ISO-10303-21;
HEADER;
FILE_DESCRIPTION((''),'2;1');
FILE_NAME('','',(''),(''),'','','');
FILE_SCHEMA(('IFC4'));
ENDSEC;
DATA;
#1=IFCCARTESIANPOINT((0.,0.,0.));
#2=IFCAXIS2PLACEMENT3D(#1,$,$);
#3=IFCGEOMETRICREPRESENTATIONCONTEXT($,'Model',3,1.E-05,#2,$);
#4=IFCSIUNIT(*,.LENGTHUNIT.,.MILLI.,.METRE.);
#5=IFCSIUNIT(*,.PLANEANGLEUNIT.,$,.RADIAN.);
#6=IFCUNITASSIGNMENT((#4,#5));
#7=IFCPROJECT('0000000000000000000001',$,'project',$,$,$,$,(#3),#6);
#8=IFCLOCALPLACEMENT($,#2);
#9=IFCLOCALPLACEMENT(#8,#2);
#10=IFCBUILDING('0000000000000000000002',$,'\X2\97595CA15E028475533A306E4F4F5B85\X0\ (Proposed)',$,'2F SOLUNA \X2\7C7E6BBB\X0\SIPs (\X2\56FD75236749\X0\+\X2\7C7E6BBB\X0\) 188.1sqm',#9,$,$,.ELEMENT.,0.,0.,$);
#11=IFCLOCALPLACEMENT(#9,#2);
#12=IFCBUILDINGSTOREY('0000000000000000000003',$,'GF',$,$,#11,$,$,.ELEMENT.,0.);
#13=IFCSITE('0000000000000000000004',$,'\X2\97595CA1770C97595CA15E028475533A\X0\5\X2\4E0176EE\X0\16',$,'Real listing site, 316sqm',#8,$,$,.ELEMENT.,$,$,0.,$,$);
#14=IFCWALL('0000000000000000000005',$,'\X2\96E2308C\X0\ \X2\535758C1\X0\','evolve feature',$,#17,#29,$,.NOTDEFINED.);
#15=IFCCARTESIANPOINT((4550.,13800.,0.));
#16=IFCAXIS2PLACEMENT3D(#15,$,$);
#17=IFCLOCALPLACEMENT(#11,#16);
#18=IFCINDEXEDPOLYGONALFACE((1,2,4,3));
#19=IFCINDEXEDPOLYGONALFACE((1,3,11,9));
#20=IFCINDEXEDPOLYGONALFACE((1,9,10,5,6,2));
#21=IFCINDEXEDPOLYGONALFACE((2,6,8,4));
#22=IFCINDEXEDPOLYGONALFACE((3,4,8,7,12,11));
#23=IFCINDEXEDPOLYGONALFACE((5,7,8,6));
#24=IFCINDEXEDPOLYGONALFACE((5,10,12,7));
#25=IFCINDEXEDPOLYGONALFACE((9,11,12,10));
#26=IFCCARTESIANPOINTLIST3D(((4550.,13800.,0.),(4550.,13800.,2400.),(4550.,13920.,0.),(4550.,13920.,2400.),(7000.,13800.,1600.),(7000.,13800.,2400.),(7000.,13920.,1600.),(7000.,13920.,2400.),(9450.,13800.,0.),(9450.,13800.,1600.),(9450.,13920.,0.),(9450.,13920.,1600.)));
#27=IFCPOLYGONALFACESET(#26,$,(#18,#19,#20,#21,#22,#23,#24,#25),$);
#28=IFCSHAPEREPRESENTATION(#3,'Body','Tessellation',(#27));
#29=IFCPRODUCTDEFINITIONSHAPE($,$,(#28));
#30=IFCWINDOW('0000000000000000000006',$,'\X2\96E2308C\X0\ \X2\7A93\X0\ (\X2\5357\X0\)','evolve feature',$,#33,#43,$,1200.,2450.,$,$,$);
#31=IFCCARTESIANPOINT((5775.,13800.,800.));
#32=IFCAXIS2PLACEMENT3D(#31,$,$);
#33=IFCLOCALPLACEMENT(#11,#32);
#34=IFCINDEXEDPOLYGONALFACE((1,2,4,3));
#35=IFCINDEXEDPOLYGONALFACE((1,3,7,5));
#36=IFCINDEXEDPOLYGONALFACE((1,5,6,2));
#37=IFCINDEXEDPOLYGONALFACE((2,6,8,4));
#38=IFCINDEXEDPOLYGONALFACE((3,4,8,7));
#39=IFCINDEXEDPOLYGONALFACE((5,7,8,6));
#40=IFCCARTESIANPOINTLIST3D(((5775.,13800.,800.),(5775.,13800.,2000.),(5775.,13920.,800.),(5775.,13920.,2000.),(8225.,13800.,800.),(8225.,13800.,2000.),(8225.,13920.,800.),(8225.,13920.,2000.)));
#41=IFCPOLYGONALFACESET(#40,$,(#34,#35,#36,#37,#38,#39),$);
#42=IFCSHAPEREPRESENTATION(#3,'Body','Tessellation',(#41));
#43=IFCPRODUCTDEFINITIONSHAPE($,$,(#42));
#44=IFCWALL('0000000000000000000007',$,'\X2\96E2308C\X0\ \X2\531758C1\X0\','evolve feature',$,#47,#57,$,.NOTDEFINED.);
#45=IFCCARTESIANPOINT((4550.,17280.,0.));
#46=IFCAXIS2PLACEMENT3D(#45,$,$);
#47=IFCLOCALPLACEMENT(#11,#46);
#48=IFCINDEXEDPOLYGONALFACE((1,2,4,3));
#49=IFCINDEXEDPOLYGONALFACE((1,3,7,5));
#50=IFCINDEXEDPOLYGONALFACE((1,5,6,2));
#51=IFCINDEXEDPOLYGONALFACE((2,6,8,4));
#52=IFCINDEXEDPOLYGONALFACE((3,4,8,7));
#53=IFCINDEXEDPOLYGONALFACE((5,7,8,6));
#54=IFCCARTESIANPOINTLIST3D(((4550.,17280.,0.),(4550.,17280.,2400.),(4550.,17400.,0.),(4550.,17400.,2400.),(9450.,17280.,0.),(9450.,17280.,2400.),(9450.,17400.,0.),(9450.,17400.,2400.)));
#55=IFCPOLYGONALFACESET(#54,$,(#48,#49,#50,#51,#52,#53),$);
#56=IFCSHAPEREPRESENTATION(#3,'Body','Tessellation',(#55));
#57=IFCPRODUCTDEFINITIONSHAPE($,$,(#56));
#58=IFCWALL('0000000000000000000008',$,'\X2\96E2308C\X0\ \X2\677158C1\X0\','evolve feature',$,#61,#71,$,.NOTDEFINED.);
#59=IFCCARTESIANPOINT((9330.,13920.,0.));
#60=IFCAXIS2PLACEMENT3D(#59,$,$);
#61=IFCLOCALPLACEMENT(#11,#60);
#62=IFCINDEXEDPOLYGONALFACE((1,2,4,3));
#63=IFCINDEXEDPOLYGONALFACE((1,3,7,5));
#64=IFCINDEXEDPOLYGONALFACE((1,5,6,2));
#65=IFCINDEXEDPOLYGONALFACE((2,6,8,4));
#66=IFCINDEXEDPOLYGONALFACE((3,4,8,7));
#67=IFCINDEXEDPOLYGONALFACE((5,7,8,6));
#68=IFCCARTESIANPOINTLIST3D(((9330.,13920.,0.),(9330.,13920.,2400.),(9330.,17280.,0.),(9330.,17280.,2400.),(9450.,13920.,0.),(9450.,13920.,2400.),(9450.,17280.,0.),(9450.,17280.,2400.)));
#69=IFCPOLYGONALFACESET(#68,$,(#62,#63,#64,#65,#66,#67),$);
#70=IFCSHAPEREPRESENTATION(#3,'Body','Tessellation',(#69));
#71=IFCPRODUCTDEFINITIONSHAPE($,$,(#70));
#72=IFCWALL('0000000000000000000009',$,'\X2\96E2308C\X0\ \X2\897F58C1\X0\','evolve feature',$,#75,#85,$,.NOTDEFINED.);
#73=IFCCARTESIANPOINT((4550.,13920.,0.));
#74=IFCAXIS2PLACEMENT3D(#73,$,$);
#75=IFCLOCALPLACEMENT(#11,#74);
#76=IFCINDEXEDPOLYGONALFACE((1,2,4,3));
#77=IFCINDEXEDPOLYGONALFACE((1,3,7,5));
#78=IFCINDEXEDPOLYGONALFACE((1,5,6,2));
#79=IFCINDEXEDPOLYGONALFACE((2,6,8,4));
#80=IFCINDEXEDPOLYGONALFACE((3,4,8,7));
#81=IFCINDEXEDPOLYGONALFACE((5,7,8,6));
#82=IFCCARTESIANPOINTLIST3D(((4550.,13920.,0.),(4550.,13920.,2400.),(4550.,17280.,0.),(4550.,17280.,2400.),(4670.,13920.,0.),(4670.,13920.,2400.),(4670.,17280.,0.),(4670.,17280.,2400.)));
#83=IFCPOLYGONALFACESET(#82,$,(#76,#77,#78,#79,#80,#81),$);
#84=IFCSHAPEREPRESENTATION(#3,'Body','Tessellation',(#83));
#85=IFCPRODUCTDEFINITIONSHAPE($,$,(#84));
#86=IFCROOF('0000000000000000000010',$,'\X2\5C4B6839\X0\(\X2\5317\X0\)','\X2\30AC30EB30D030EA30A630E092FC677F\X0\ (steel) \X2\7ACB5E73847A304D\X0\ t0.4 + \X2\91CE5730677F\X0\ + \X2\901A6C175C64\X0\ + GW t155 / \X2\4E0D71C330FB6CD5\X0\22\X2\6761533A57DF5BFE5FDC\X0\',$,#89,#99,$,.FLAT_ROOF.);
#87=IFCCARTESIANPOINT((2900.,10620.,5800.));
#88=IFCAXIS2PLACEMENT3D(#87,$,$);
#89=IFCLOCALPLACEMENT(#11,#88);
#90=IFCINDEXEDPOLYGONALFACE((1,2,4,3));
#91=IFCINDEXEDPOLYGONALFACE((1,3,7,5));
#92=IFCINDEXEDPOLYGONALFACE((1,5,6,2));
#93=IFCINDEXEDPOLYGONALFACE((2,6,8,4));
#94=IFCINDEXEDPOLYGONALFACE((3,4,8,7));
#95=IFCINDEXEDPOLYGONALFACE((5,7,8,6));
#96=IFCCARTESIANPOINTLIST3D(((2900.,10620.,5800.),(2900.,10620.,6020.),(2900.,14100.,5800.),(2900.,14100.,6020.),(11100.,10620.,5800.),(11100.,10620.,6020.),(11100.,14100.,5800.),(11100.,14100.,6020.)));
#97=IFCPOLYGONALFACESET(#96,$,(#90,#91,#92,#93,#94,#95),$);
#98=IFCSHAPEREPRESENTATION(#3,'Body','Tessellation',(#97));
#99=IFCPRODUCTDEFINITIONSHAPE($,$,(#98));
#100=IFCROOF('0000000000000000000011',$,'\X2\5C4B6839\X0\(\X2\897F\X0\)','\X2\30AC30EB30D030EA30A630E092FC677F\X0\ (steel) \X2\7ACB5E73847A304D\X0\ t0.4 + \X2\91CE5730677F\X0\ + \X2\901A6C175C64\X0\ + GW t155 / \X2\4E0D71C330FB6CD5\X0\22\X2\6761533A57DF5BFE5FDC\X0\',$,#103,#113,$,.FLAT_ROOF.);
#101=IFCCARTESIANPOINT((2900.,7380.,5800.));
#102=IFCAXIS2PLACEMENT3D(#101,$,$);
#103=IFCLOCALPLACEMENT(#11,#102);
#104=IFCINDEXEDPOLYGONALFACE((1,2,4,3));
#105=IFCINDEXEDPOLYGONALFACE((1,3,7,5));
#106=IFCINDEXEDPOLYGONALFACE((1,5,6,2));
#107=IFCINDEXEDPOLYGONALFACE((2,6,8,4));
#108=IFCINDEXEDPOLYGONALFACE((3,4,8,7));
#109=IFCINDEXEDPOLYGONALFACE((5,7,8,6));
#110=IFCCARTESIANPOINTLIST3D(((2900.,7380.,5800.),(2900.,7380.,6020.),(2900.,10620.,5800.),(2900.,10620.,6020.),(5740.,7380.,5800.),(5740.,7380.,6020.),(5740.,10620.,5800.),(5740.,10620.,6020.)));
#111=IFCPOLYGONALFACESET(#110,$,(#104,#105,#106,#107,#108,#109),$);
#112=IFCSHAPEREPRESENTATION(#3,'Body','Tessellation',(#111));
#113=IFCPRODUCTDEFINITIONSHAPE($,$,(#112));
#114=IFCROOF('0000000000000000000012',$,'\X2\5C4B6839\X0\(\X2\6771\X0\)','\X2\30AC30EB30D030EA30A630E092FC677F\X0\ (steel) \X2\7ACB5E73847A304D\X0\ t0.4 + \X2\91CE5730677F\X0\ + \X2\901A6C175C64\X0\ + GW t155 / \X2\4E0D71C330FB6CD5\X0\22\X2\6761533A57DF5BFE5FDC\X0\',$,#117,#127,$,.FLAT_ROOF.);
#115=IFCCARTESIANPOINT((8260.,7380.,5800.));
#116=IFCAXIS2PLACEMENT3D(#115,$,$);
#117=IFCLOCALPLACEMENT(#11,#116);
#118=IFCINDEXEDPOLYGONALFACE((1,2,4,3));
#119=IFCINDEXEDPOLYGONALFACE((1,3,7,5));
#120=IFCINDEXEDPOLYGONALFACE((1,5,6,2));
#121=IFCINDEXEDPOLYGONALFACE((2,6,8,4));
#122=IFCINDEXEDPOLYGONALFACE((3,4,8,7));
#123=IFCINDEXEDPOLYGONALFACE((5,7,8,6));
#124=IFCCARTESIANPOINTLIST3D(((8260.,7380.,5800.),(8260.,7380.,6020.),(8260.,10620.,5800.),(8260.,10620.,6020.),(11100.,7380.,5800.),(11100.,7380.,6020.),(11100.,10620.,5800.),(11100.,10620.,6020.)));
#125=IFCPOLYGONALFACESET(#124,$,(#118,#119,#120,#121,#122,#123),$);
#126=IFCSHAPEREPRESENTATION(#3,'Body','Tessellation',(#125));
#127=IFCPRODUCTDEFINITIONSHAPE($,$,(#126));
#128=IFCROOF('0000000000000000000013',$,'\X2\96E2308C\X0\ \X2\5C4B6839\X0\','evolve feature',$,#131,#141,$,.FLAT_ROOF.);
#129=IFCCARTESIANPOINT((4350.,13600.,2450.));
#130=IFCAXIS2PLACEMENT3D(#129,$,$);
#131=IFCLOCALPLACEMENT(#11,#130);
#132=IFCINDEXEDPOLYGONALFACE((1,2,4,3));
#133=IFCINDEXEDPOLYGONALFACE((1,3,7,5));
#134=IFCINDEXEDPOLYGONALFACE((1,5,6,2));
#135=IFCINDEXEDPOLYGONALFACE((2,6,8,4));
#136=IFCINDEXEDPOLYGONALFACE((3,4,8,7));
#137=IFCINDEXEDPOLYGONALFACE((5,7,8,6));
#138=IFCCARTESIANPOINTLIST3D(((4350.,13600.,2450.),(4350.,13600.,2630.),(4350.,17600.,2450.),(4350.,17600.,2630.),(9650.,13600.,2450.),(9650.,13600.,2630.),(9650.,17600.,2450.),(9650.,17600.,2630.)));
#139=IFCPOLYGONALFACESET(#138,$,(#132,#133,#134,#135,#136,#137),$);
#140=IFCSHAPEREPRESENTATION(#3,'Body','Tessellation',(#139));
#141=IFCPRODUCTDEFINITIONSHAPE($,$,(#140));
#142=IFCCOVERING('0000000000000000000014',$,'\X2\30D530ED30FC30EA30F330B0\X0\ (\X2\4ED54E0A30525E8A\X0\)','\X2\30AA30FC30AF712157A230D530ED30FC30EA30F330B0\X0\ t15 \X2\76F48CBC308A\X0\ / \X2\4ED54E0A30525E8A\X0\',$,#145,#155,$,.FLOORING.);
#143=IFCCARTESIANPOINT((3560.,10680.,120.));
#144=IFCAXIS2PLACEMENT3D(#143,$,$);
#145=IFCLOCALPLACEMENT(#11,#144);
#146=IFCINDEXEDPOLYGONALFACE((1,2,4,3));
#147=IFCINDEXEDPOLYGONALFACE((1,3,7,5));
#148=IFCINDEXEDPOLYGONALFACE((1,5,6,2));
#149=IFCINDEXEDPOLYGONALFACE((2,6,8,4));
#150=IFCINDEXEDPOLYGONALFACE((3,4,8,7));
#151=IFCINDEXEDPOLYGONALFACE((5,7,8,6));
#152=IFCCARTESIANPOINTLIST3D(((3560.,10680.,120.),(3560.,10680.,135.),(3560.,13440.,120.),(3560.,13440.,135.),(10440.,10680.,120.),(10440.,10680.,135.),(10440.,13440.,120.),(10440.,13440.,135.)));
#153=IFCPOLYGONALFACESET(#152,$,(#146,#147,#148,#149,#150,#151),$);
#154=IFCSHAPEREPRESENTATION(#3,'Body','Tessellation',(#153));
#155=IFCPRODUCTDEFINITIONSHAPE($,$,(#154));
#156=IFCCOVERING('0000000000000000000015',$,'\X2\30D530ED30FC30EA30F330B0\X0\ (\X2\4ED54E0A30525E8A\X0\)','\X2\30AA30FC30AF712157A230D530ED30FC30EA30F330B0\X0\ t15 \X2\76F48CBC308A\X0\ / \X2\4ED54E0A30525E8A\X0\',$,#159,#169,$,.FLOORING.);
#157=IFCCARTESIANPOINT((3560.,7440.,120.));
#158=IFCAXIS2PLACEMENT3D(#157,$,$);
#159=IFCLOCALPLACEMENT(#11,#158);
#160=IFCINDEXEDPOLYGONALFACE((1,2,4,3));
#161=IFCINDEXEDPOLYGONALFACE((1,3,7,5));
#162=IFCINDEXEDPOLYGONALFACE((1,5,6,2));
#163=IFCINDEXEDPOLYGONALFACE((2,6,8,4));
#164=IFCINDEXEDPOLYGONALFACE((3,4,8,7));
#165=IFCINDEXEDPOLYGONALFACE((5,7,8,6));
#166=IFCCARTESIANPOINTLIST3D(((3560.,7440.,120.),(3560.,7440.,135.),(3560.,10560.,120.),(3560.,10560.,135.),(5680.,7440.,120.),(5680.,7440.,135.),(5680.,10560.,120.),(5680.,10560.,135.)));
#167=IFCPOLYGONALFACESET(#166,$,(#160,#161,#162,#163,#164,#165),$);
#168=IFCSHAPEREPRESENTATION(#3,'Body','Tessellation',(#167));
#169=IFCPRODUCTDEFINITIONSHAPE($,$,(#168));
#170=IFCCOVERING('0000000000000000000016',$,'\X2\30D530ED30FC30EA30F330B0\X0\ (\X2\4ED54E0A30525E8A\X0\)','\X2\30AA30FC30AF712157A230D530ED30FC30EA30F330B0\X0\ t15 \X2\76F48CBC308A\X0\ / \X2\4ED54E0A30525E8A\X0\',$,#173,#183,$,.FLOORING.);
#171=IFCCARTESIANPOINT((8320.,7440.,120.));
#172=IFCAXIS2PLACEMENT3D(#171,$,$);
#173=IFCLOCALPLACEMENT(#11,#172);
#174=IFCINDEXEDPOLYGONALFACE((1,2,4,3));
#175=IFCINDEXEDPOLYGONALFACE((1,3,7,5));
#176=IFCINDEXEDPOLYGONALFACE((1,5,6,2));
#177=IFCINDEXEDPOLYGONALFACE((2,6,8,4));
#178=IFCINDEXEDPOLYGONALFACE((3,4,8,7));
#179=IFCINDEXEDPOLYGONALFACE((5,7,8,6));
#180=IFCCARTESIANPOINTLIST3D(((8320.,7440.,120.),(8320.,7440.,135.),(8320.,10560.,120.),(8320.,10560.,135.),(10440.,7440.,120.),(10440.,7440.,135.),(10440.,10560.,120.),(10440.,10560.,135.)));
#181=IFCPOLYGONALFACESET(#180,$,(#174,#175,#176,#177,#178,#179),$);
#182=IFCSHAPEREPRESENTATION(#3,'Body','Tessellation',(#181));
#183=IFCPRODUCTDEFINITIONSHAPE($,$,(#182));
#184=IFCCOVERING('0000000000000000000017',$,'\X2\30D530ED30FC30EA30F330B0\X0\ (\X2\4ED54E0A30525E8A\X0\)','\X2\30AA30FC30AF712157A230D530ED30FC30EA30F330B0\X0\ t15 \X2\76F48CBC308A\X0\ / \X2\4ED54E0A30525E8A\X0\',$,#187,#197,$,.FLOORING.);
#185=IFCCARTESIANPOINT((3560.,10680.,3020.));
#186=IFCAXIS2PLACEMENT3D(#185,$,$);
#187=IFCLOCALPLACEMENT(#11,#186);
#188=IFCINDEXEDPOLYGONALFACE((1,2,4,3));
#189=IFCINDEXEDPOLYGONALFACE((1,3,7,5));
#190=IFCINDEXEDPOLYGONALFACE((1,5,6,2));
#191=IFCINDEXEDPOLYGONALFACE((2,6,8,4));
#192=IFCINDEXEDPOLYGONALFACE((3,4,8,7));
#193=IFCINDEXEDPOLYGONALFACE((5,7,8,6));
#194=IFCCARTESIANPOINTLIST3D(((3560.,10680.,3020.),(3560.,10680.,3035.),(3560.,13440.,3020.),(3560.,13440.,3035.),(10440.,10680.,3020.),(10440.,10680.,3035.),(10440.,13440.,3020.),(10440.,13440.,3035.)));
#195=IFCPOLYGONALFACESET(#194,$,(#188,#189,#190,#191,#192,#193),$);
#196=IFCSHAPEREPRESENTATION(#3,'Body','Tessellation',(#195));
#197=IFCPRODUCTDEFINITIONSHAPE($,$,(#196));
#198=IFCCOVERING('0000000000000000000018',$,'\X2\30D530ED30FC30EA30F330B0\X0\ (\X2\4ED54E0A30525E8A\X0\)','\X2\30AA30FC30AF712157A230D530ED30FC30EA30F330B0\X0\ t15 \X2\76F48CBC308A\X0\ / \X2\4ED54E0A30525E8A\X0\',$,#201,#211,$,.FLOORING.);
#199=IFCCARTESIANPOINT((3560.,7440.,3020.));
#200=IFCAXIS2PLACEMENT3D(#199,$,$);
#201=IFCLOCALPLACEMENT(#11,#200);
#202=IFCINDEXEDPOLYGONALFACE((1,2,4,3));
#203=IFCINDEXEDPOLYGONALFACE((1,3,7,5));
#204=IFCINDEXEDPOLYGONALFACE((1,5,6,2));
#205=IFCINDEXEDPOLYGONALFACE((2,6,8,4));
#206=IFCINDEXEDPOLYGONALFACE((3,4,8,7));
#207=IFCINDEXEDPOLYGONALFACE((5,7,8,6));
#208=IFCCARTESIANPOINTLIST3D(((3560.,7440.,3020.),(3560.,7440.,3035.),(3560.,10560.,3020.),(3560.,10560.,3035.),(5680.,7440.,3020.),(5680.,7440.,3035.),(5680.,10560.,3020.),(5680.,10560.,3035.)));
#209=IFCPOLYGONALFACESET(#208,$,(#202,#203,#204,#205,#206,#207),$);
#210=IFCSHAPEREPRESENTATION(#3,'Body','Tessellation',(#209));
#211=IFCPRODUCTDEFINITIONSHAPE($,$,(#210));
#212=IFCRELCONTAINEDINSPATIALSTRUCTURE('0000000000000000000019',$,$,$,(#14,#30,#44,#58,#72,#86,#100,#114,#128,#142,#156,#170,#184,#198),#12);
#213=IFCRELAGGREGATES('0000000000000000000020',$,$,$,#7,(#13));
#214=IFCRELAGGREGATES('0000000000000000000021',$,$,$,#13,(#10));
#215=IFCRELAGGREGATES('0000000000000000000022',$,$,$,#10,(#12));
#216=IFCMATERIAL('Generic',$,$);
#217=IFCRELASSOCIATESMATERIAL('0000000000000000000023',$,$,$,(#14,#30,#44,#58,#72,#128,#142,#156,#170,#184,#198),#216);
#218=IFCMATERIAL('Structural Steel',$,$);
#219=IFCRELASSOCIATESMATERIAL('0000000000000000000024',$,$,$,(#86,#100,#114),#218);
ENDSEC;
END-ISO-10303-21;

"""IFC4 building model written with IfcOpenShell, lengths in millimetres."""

from ifc_helpers import new_model, si_unit, frame, frame_2d, origin, place, context, project, spatial, rectangle, extrude, material, element, fill, save


model = new_model("IFC4")

# Units and contexts
model_context = context("Model", 3, precision=1e-05, world=origin())
ifc_project = project(units=[si_unit("LENGTHUNIT", "METRE", prefix="MILLI"), si_unit("PLANEANGLEUNIT", "RADIAN")], contexts=[model_context])

# Site, building, storey
site_placement = place(None, origin())
site = spatial("IfcSite", under=ifc_project, at=site_placement, Name="静岡県静岡市葵区5丁目16", ObjectType="Real listing site, 316sqm", CompositionType="ELEMENT", RefElevation=0.0)
building_placement = place(site_placement, origin())
building = spatial("IfcBuilding", under=site, at=building_placement, Name="静岡市葵区の住宅 (Proposed)", ObjectType="2F SOLUNA 籾殻SIPs (国産杉+籾殻) 188.1sqm", CompositionType="ELEMENT", ElevationOfRefHeight=0.0, ElevationOfTerrain=0.0)
storey_placement = place(building_placement, origin())
storey = spatial("IfcBuildingStorey", under=building, at=storey_placement, Name="GF", CompositionType="ELEMENT", Elevation=0.0)

# Shared definitions
ifc_material_1 = material(Name="Generic")

# Wall, opening, window
wall_1_placement = place(storey_placement, frame((4550.0, 13800.0, 0.0)))
wall_1 = element("IfcWall", 1, at=wall_1_placement, inside=storey, material=ifc_material_1, Name="離れ 南壁", Description="evolve feature", PredefinedType="NOTDEFINED", context=model_context, shape_type="SweptSolid", body=[
    extrude(rectangle(XDim=4900.0, YDim=120.0, at=frame_2d((2450.0, 60.0))), frame((4550.0, 13800.0, 0.0)), (0.0, 0.0, 1.0), 2400.0),
])
opening_1_placement = place(storey_placement, frame((5775.0, 13800.0, 800.0)))
opening_1 = element("IfcOpeningElement", 2, at=opening_1_placement, cuts=wall_1, PredefinedType="NOTDEFINED", context=model_context, shape_type="SweptSolid", body=[
    extrude(rectangle(XDim=2450.0, YDim=120.0, at=frame_2d((1225.0, 60.0))), frame((5775.0, 13800.0, 800.0)), (0.0, 0.0, 1.0), 1200.0),
])
window_1_placement = place(storey_placement, frame((5775.0, 13800.0, 800.0)))
window_1 = element("IfcWindow", 3, at=window_1_placement, inside=storey, material=ifc_material_1, Name="離れ 窓 (南)", Description="evolve feature", OverallHeight=1200.0, OverallWidth=2450.0, context=model_context, shape_type="SweptSolid", body=[
    extrude(rectangle(XDim=2450.0, YDim=120.0, at=frame_2d((1225.0, 60.0))), frame((5775.0, 13800.0, 800.0)), (0.0, 0.0, 1.0), 1200.0),
])
fill(opening_1, window_1)

# Walls
wall_2_placement = place(storey_placement, frame((4550.0, 17280.0, 0.0)))
element("IfcWall", 4, at=wall_2_placement, inside=storey, material=ifc_material_1, Name="離れ 北壁", Description="evolve feature", PredefinedType="NOTDEFINED", context=model_context, shape_type="SweptSolid", body=[
    extrude(rectangle(XDim=4900.0, YDim=120.0, at=frame_2d((2450.0, 60.0))), frame((4550.0, 17280.0, 0.0)), (0.0, 0.0, 1.0), 2400.0),
])
wall_3_placement = place(storey_placement, frame((9330.0, 13920.0, 0.0)))
element("IfcWall", 5, at=wall_3_placement, inside=storey, material=ifc_material_1, Name="離れ 東壁", Description="evolve feature", PredefinedType="NOTDEFINED", context=model_context, shape_type="SweptSolid", body=[
    extrude(rectangle(XDim=120.0, YDim=3360.0, at=frame_2d((60.0, 1680.0))), frame((9330.0, 13920.0, 0.0)), (0.0, 0.0, 1.0), 2400.0),
])
wall_4_placement = place(storey_placement, frame((4550.0, 13920.0, 0.0)))
element("IfcWall", 6, at=wall_4_placement, inside=storey, material=ifc_material_1, Name="離れ 西壁", Description="evolve feature", PredefinedType="NOTDEFINED", context=model_context, shape_type="SweptSolid", body=[
    extrude(rectangle(XDim=120.0, YDim=3360.0, at=frame_2d((60.0, 1680.0))), frame((4550.0, 13920.0, 0.0)), (0.0, 0.0, 1.0), 2400.0),
])

# Roofs
ifc_material_2 = material(Name="Structural Steel")
for number, where, name in (
    (7, (2900.0, 10620.0, 5800.0), "屋根(北)"),
):
    element("IfcRoof", number, at=place(storey_placement, frame(where)), inside=storey, material=ifc_material_2, Name=name, Description="ガルバリウム鋼板 (steel) 立平葺き t0.4 + 野地板 + 通気層 + GW t155 / 不燃・法22条区域対応", PredefinedType="FLAT_ROOF", context=model_context, shape_type="SweptSolid", body=[
        extrude(rectangle(XDim=8200.0, YDim=3480.0, at=frame_2d((4100.0, 1740.0))), frame((2900.0, 10620.0, 5800.0)), (0.0, 0.0, 1.0), 220.0),
    ])
roof_1_placement = place(storey_placement, frame((2900.0, 7380.0, 5800.0)))
element("IfcRoof", 8, at=roof_1_placement, inside=storey, material=ifc_material_2, Name="屋根(西)", Description="ガルバリウム鋼板 (steel) 立平葺き t0.4 + 野地板 + 通気層 + GW t155 / 不燃・法22条区域対応", PredefinedType="FLAT_ROOF", context=model_context, shape_type="SweptSolid", body=[
    extrude(rectangle(XDim=2840.0, YDim=3240.0, at=frame_2d((1420.0, 1620.0))), frame((2900.0, 7380.0, 5800.0)), (0.0, 0.0, 1.0), 220.0),
])
roof_2_placement = place(storey_placement, frame((8260.0, 7380.0, 5800.0)))
element("IfcRoof", 9, at=roof_2_placement, inside=storey, material=ifc_material_2, Name="屋根(東)", Description="ガルバリウム鋼板 (steel) 立平葺き t0.4 + 野地板 + 通気層 + GW t155 / 不燃・法22条区域対応", PredefinedType="FLAT_ROOF", context=model_context, shape_type="SweptSolid", body=[
    extrude(rectangle(XDim=2840.0, YDim=3240.0, at=frame_2d((1420.0, 1620.0))), frame((8260.0, 7380.0, 5800.0)), (0.0, 0.0, 1.0), 220.0),
])
roof_3_placement = place(storey_placement, frame((4350.0, 13600.0, 2450.0)))
element("IfcRoof", 10, at=roof_3_placement, inside=storey, material=ifc_material_1, Name="離れ 屋根", Description="evolve feature", PredefinedType="FLAT_ROOF", context=model_context, shape_type="SweptSolid", body=[
    extrude(rectangle(XDim=5300.0, YDim=4000.0, at=frame_2d((2650.0, 2000.0))), frame((4350.0, 13600.0, 2450.0)), (0.0, 0.0, 1.0), 180.0),
])

# Coverings
covering_1_placement = place(storey_placement, frame((3560.0, 10680.0, 120.0)))
element("IfcCovering", 11, at=covering_1_placement, inside=storey, material=ifc_material_1, Name="フローリング (仕上げ床)", Description="オーク無垢フローリング t15 直貼り / 仕上げ床", PredefinedType="FLOORING", context=model_context, shape_type="SweptSolid", body=[
    extrude(rectangle(XDim=6880.0, YDim=2760.0, at=frame_2d((3440.0, 1380.0))), frame((3560.0, 10680.0, 120.0)), (0.0, 0.0, 1.0), 15.0),
])
covering_2_placement = place(storey_placement, frame((3560.0, 7440.0, 120.0)))
element("IfcCovering", 12, at=covering_2_placement, inside=storey, material=ifc_material_1, Name="フローリング (仕上げ床)", Description="オーク無垢フローリング t15 直貼り / 仕上げ床", PredefinedType="FLOORING", context=model_context, shape_type="SweptSolid", body=[
    extrude(rectangle(XDim=2120.0, YDim=3120.0, at=frame_2d((1060.0, 1560.0))), frame((3560.0, 7440.0, 120.0)), (0.0, 0.0, 1.0), 15.0),
])
covering_3_placement = place(storey_placement, frame((8320.0, 7440.0, 120.0)))
element("IfcCovering", 13, at=covering_3_placement, inside=storey, material=ifc_material_1, Name="フローリング (仕上げ床)", Description="オーク無垢フローリング t15 直貼り / 仕上げ床", PredefinedType="FLOORING", context=model_context, shape_type="SweptSolid", body=[
    extrude(rectangle(XDim=2120.0, YDim=3120.0, at=frame_2d((1060.0, 1560.0))), frame((8320.0, 7440.0, 120.0)), (0.0, 0.0, 1.0), 15.0),
])
covering_4_placement = place(storey_placement, frame((3560.0, 10680.0, 3020.0)))
element("IfcCovering", 14, at=covering_4_placement, inside=storey, material=ifc_material_1, Name="フローリング (仕上げ床)", Description="オーク無垢フローリング t15 直貼り / 仕上げ床", PredefinedType="FLOORING", context=model_context, shape_type="SweptSolid", body=[
    extrude(rectangle(XDim=6880.0, YDim=2760.0, at=frame_2d((3440.0, 1380.0))), frame((3560.0, 10680.0, 3020.0)), (0.0, 0.0, 1.0), 15.0),
])
covering_5_placement = place(storey_placement, frame((3560.0, 7440.0, 3020.0)))
element("IfcCovering", 15, at=covering_5_placement, inside=storey, material=ifc_material_1, Name="フローリング (仕上げ床)", Description="オーク無垢フローリング t15 直貼り / 仕上げ床", PredefinedType="FLOORING", context=model_context, shape_type="SweptSolid", body=[
    extrude(rectangle(XDim=2120.0, YDim=3120.0, at=frame_2d((1060.0, 1560.0))), frame((3560.0, 7440.0, 3020.0)), (0.0, 0.0, 1.0), 15.0),
])

save(model, "model.ifc")
